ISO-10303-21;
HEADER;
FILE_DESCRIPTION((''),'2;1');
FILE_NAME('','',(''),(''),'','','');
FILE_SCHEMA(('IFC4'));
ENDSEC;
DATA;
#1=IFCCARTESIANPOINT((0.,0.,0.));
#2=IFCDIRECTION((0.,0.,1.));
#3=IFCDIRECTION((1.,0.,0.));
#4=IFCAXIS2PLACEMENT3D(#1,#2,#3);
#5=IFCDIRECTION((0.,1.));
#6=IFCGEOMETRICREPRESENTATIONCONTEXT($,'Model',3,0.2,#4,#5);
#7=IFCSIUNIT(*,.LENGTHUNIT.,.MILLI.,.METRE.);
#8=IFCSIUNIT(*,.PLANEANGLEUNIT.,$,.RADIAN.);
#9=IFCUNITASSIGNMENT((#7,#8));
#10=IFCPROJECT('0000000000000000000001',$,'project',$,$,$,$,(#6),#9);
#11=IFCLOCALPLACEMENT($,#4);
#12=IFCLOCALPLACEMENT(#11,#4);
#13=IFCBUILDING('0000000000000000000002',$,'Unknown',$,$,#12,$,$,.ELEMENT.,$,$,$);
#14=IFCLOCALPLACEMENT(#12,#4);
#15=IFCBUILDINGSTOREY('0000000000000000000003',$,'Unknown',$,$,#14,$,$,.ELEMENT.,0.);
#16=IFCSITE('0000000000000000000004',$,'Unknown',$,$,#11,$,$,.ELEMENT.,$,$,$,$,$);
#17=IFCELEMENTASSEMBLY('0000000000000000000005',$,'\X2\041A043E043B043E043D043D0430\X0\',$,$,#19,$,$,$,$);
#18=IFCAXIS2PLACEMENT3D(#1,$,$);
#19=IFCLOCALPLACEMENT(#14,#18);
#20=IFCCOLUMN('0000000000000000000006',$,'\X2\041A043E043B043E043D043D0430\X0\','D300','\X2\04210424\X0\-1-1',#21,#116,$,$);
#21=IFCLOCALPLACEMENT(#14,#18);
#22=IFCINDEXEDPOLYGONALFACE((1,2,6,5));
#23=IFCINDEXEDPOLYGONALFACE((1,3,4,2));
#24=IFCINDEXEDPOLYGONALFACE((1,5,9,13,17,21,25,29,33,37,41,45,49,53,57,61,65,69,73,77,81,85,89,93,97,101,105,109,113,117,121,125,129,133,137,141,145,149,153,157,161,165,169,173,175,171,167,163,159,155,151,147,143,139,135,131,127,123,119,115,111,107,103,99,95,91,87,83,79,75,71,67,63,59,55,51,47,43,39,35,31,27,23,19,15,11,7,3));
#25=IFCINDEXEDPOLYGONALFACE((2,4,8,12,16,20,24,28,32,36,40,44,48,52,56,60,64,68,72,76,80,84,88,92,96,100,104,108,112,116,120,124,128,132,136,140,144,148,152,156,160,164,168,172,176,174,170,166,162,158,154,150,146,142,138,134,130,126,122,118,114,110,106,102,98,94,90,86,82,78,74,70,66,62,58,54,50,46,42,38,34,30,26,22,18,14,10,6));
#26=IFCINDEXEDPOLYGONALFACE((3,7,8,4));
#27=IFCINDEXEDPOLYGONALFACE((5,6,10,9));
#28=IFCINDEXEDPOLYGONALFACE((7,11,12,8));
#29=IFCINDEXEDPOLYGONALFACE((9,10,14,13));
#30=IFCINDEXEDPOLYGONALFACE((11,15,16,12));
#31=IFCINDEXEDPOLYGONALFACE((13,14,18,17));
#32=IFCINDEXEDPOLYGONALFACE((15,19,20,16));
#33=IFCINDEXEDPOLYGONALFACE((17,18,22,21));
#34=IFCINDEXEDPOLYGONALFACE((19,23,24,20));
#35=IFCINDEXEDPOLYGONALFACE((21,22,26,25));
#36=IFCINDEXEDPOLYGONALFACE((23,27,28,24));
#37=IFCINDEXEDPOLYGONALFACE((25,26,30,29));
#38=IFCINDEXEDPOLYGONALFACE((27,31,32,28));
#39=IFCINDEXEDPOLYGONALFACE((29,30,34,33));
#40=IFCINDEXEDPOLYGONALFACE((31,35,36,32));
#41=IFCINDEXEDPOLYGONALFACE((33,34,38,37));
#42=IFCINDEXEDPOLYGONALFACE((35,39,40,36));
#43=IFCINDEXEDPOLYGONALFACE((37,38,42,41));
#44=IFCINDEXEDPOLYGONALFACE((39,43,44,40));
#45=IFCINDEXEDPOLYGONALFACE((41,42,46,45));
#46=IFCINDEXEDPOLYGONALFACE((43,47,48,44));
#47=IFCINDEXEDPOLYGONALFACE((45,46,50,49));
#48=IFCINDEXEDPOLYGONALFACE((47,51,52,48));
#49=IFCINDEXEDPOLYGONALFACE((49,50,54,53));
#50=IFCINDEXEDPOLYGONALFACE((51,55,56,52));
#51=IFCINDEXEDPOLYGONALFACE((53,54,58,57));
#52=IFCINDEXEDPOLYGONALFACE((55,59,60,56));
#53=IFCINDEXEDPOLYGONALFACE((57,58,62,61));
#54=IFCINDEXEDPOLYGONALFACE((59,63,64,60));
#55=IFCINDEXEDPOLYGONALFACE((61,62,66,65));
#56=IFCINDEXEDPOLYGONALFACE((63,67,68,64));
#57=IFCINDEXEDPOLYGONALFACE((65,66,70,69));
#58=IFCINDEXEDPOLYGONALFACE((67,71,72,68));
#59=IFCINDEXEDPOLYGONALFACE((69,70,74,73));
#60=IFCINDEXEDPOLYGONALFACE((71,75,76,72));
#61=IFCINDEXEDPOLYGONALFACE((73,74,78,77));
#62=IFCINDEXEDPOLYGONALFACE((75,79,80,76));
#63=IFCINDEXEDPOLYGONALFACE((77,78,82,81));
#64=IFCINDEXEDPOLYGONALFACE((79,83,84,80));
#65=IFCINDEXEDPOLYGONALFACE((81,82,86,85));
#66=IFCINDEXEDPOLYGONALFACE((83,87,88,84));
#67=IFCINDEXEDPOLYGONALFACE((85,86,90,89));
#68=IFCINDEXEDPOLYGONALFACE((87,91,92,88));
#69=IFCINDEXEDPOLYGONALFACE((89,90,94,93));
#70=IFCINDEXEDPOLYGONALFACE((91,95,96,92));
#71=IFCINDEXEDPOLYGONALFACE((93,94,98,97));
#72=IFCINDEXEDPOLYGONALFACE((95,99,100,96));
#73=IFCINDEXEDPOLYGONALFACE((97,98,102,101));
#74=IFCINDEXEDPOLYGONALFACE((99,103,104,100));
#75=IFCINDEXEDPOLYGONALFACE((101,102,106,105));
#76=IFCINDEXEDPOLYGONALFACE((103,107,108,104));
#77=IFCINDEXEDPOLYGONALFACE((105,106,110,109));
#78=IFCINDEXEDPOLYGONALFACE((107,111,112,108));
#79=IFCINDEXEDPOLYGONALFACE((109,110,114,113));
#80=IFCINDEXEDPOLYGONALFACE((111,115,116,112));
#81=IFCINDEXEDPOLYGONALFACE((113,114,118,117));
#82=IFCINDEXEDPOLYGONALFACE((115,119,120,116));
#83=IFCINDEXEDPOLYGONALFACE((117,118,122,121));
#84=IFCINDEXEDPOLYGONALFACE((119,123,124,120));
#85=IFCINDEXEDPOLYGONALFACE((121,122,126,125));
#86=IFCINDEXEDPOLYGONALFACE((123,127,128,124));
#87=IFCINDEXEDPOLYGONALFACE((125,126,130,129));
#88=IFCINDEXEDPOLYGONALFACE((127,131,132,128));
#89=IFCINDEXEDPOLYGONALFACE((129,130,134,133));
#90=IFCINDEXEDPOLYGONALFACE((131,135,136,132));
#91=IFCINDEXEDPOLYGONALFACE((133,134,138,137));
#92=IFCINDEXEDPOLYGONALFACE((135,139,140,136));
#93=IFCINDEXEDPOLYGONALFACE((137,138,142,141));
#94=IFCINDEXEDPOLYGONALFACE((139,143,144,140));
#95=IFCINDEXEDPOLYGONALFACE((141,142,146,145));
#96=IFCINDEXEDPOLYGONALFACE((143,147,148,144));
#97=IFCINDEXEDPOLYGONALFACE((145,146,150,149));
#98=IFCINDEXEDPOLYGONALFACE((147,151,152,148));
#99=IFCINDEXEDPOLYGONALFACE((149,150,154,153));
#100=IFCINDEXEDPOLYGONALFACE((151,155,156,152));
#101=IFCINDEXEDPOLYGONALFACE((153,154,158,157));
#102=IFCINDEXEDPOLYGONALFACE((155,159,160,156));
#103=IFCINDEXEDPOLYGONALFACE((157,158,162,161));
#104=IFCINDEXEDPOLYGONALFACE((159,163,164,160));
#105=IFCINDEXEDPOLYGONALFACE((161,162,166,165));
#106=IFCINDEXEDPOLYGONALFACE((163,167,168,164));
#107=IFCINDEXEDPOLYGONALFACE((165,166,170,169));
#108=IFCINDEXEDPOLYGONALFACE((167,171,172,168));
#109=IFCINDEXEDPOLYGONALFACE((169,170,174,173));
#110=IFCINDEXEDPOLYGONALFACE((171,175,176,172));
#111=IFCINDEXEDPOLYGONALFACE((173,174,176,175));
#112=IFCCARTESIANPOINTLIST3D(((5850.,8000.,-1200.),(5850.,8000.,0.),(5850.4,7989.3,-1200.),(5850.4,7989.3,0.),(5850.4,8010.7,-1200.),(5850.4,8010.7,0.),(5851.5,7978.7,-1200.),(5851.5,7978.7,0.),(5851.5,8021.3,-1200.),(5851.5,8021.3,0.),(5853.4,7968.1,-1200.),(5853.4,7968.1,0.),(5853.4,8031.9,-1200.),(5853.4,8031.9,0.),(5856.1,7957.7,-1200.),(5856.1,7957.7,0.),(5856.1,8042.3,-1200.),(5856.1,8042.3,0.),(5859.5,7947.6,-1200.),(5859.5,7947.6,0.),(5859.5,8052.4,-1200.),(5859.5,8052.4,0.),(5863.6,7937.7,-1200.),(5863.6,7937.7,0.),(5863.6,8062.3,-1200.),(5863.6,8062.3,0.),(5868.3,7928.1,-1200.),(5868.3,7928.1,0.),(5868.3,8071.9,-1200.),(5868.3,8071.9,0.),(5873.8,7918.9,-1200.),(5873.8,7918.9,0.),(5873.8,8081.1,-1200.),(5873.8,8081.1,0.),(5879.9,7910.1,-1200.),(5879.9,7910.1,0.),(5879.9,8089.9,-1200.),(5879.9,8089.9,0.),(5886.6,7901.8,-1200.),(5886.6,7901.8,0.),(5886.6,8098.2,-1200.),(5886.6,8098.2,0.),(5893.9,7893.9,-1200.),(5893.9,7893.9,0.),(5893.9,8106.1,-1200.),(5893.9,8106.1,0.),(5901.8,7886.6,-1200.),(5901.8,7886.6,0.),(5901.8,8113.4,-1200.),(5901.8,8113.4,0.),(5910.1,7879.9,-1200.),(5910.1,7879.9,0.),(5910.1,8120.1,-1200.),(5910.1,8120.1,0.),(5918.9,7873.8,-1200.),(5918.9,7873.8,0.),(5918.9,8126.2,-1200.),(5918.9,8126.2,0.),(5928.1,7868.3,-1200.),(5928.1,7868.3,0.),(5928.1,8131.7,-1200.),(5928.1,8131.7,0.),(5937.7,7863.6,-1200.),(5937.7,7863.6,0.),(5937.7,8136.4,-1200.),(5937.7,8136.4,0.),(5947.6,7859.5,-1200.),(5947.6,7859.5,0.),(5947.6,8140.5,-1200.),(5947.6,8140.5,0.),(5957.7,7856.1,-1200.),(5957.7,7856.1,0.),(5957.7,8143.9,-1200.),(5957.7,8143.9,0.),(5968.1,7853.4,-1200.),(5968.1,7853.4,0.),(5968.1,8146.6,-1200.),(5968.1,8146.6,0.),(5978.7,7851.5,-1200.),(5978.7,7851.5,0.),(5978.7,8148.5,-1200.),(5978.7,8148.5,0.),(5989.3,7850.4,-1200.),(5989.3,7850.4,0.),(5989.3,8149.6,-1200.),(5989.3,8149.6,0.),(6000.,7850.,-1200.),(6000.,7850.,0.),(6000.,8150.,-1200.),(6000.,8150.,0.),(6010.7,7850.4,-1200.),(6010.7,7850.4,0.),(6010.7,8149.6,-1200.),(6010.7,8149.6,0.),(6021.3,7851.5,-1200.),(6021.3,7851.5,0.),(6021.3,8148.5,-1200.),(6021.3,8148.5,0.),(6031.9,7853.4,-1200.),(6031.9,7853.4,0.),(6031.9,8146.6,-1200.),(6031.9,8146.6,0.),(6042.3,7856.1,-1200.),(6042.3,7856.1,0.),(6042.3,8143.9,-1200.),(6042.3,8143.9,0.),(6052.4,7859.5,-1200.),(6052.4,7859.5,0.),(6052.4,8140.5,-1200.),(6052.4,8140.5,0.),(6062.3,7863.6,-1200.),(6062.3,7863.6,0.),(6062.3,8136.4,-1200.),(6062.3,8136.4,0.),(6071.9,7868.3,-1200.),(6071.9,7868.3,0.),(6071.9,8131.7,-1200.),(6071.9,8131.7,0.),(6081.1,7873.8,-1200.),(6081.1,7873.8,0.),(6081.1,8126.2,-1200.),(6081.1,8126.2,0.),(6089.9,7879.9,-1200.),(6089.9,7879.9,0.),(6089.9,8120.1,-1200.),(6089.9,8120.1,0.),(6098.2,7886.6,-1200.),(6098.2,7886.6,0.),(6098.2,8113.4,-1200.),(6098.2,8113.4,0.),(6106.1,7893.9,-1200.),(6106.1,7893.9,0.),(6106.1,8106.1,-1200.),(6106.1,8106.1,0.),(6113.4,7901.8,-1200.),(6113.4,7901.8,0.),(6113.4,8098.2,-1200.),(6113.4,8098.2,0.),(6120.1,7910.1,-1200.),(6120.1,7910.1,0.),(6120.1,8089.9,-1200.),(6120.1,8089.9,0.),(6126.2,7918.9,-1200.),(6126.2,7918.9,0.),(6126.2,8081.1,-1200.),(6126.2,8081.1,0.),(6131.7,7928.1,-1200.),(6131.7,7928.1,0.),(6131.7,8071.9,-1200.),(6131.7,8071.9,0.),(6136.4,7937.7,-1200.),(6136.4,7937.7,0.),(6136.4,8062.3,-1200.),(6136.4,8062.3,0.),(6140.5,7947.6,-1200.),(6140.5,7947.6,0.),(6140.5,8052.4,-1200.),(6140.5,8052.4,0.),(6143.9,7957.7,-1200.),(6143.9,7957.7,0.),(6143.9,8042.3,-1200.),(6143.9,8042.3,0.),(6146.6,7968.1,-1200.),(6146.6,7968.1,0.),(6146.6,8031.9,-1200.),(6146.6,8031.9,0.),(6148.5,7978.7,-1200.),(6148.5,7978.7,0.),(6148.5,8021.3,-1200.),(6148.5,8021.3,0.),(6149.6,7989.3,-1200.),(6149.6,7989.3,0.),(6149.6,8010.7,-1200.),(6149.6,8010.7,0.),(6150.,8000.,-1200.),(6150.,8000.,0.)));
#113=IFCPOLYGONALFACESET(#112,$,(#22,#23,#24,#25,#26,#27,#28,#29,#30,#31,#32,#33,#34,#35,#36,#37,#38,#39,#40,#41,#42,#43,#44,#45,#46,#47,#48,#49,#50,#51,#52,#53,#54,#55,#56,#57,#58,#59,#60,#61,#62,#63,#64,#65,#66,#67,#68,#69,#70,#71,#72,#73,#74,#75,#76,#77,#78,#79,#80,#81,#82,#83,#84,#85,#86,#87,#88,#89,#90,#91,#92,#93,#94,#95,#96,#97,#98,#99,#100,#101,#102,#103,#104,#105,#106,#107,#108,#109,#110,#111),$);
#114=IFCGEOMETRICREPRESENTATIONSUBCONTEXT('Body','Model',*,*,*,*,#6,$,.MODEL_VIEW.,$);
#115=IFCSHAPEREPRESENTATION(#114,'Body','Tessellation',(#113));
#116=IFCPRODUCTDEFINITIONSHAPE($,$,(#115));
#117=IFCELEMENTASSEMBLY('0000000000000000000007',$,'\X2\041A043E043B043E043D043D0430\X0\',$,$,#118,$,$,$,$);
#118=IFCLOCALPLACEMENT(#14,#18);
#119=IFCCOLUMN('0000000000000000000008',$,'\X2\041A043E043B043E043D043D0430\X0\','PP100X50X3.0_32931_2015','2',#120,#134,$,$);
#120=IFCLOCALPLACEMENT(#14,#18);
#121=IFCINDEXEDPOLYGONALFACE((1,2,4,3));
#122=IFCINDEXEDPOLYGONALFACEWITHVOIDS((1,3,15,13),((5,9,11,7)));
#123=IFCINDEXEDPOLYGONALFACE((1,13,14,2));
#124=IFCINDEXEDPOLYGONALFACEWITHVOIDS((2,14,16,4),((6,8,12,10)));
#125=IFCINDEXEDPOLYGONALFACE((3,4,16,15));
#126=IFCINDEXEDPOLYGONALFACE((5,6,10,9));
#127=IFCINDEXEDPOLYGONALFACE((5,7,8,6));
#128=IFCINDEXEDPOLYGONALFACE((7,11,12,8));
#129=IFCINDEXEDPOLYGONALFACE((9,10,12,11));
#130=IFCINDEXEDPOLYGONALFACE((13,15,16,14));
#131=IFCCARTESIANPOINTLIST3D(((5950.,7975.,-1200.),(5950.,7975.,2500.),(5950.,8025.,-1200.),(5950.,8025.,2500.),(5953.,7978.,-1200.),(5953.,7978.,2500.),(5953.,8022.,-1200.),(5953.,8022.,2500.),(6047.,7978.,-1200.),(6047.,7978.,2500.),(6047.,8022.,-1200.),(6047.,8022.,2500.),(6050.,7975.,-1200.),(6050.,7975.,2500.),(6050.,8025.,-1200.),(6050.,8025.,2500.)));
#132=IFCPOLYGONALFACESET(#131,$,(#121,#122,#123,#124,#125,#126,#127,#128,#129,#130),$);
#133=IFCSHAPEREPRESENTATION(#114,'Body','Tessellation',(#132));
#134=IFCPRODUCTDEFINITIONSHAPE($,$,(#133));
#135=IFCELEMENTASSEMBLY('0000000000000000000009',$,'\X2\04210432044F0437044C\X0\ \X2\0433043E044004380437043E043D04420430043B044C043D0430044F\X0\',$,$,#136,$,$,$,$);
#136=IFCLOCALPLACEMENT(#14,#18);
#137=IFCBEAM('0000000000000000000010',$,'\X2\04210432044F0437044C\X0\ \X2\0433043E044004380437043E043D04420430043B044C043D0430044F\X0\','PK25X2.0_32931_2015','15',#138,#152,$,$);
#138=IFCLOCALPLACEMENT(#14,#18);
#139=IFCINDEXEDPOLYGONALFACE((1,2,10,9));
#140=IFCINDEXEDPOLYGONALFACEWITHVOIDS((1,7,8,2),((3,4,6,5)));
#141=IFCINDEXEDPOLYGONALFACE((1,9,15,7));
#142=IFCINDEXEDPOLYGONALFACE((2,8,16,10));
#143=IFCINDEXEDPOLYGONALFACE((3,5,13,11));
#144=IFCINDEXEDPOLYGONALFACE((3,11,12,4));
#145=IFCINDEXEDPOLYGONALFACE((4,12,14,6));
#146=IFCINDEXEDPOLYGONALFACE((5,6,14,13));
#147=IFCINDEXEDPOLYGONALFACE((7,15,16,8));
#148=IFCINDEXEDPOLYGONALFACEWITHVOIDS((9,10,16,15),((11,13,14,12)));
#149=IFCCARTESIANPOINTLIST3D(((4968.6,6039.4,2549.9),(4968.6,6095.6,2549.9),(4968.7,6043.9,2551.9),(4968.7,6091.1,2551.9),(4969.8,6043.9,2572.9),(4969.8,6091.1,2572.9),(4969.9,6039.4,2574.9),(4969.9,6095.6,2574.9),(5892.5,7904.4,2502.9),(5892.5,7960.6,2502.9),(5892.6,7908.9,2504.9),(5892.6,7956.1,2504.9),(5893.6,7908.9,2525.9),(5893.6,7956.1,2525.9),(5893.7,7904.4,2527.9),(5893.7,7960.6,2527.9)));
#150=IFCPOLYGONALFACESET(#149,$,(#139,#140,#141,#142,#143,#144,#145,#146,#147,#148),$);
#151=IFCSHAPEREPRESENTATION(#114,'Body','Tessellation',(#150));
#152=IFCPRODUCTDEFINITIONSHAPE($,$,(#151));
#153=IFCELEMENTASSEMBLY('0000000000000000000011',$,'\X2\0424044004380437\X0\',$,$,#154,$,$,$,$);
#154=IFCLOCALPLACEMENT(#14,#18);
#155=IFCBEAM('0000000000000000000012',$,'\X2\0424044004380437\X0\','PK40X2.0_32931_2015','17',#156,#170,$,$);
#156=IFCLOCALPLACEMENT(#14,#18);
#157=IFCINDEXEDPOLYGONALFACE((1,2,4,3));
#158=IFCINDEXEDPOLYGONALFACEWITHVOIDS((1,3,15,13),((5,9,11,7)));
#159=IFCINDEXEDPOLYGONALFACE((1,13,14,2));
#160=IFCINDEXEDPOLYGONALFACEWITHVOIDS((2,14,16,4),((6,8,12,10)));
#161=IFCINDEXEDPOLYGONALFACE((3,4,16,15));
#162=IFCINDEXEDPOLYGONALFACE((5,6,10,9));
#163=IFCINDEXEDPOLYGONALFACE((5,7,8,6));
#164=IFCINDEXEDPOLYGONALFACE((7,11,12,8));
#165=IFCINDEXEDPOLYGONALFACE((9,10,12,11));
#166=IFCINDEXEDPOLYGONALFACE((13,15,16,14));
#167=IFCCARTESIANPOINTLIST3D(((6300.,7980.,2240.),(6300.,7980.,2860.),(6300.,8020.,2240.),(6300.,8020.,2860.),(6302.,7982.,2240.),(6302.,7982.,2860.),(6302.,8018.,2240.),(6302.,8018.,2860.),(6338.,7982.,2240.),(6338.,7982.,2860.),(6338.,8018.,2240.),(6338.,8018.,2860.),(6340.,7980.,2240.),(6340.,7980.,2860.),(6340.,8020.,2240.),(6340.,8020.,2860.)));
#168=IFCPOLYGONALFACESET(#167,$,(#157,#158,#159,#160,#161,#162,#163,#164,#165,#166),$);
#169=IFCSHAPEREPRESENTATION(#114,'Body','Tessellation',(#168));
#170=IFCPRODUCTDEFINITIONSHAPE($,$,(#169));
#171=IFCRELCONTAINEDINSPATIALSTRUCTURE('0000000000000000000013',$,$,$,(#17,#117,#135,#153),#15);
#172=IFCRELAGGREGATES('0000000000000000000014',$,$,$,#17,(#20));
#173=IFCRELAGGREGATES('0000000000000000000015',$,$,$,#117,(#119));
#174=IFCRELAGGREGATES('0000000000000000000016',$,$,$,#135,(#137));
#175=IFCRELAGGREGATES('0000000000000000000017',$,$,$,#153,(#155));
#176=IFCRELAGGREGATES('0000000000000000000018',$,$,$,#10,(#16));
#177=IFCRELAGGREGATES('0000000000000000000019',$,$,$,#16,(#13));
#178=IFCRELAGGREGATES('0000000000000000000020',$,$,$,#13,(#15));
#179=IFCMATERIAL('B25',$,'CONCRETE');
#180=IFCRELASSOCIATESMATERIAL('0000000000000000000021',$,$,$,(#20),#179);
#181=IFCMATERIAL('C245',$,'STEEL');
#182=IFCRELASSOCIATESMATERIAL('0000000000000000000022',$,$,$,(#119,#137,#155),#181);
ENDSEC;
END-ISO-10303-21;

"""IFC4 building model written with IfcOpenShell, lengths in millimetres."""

from ifc_helpers import new_model, si_unit, direction, frame, origin_with_axes, place, context, subcontext, project, spatial, line, indexed_curve, outline, extrude, material, element, aggregate, save


model = new_model("IFC4")

# Units and contexts
model_context = context("Model", 3, precision=0.2, world=origin_with_axes(), true_north=direction((0.0, 1.0)))
body_context = subcontext(model_context, "Body", "Model", "MODEL_VIEW")
ifc_project = project(units=[si_unit("LENGTHUNIT", "METRE", prefix="MILLI"), si_unit("PLANEANGLEUNIT", "RADIAN")], contexts=[model_context])

# Site, building, storey
site_placement = place(None, origin_with_axes())
site = spatial("IfcSite", under=ifc_project, at=site_placement, Name="Unknown", CompositionType="ELEMENT")
building_placement = place(site_placement, origin_with_axes())
building = spatial("IfcBuilding", under=site, at=building_placement, Name="Unknown", CompositionType="ELEMENT")
storey_placement = place(building_placement, origin_with_axes())
storey = spatial("IfcBuildingStorey", under=building, at=storey_placement, Name="Unknown", CompositionType="ELEMENT", Elevation=0.0)

# Element assemblies, columns
assembly_1_placement = place(storey_placement, frame((6000.0, 8000.0, -1200.0), z_axis=(-1.0, 0.0, 0.0), x_axis=(0.0, 0.0, 1.0)))
assembly_1 = element("IfcElementAssembly", 1, at=assembly_1_placement, inside=storey, Name="Колонна")
ifc_material_1 = material(Name="B25", Category="CONCRETE")
column_1_placement = place(assembly_1_placement, origin_with_axes())
column_1 = element("IfcColumn", 2, at=column_1_placement, material=ifc_material_1, Name="Колонна", Description="D300", ObjectType="СФ-1-1", context=body_context, shape_type="SolidModel", body=[
    extrude(outline(indexed_curve([(150.0, 0.0), (149.6, 10.7), (148.5, 21.3), (146.6, 31.9), (143.9, 42.3), (140.5, 52.4), (136.4, 62.3), (131.7, 71.9), (126.2, 81.1), (120.1, 89.9), (113.4, 98.2), (106.1, 106.1), (98.2, 113.4), (89.9, 120.1), (81.1, 126.2), (71.9, 131.7), (62.3, 136.4), (52.4, 140.5), (42.3, 143.9), (31.9, 146.6), (21.3, 148.5), (10.7, 149.6), (0.0, 150.0), (-10.7, 149.6), (-21.3, 148.5), (-31.9, 146.6), (-42.3, 143.9), (-52.4, 140.5), (-62.3, 136.4), (-71.9, 131.7), (-81.1, 126.2), (-89.9, 120.1), (-98.2, 113.4), (-106.1, 106.1), (-113.4, 98.2), (-120.1, 89.9), (-126.2, 81.1), (-131.7, 71.9), (-136.4, 62.3), (-140.5, 52.4), (-143.9, 42.3), (-146.6, 31.9), (-148.5, 21.3), (-149.6, 10.7), (-150.0, 0.0), (-149.6, -10.7), (-148.5, -21.3), (-146.6, -31.9), (-143.9, -42.3), (-140.5, -52.4), (-136.4, -62.3), (-131.7, -71.9), (-126.2, -81.1), (-120.1, -89.9), (-113.4, -98.2), (-106.1, -106.1), (-98.2, -113.4), (-89.9, -120.1), (-81.1, -126.2), (-71.9, -131.7), (-62.3, -136.4), (-52.4, -140.5), (-42.3, -143.9), (-31.9, -146.6), (-21.3, -148.5), (-10.7, -149.6), (0.0, -150.0), (10.7, -149.6), (21.3, -148.5), (31.9, -146.6), (42.3, -143.9), (52.4, -140.5), (62.3, -136.4), (71.9, -131.7), (81.1, -126.2), (89.9, -120.1), (98.2, -113.4), (106.1, -106.1), (113.4, -98.2), (120.1, -89.9), (126.2, -81.1), (131.7, -71.9), (136.4, -62.3), (140.5, -52.4), (143.9, -42.3), (146.6, -31.9), (148.5, -21.3), (149.6, -10.7)], segments=[line(1, 2, 3, 4, 5, 6, 7, 8, 9, 10, 11, 12, 13, 14, 15, 16, 17, 18, 19, 20, 21, 22, 23, 24, 25, 26, 27, 28, 29, 30, 31, 32, 33, 34, 35, 36, 37, 38, 39, 40, 41, 42, 43, 44, 45, 46, 47, 48, 49, 50, 51, 52, 53, 54, 55, 56, 57, 58, 59, 60, 61, 62, 63, 64, 65, 66, 67, 68, 69, 70, 71, 72, 73, 74, 75, 76, 77, 78, 79, 80, 81, 82, 83, 84, 85, 86, 87, 88, 1)])), frame((0.0, 0.0, 0.0), z_axis=(-1.0, 0.0, 0.0), x_axis=(0.0, 0.0, 1.0)), (0.0, 0.0, -1.0), 1200.0),
])
aggregate(assembly_1, [column_1])
assembly_2_placement = place(storey_placement, frame((6000.0, 8000.0, -1200.0), z_axis=(0.0, -1.0, 0.0), x_axis=(0.0, 0.0, 1.0)))
assembly_2 = element("IfcElementAssembly", 3, at=assembly_2_placement, inside=storey, Name="Колонна")
ifc_material_2 = material(Name="C245", Category="STEEL")
column_2_placement = place(assembly_2_placement, origin_with_axes())
column_2 = element("IfcColumn", 4, at=column_2_placement, material=ifc_material_2, Name="Колонна", Description="PP100X50X3.0_32931_2015", ObjectType="2", context=body_context, shape_type="SolidModel", body=[
    extrude(outline(indexed_curve([(-25.0, -50.0), (25.0, -50.0), (25.0, 50.0), (-25.0, 50.0)], segments=[line(1, 2, 3, 4, 1)]), holes=[indexed_curve([(-22.0, -47.0), (-22.0, 47.0), (22.0, 47.0), (22.0, -47.0)], segments=[line(1, 2, 3, 4, 1)])]), frame((0.0, 0.0, 0.0), z_axis=(-1.0, 0.0, 0.0), x_axis=(0.0, 0.0, 1.0)), (0.0, 0.0, -1.0), 3700.0),
])
aggregate(assembly_2, [column_2])

# Element assembly, beam, voiding features
assembly_3_placement = place(storey_placement, frame((5920.3, 7987.4, 2514.0), z_axis=(-0.894709, 0.444326, 0.045494), x_axis=(-0.443753, -0.895865, 0.022564)))
assembly_3 = element("IfcElementAssembly", 5, at=assembly_3_placement, inside=storey, Name="Связь горизонтальная")
beam_1_placement = place(assembly_3_placement, origin_with_axes())
beam_1 = element("IfcBeam", 6, at=beam_1_placement, material=ifc_material_2, Name="Связь горизонтальная", Description="PK25X2.0_32931_2015", ObjectType="15", context=body_context, shape_type="SolidModel", body=[
    extrude(outline(indexed_curve([(-12.5, -12.5), (12.5, -12.5), (12.5, 12.5), (-12.5, 12.5)], segments=[line(1, 2, 3, 4, 1)]), holes=[indexed_curve([(-10.5, -10.5), (-10.5, 10.5), (10.5, 10.5), (10.5, -10.5)], segments=[line(1, 2, 3, 4, 1)])]), frame((0.0, 0.0, 0.0), z_axis=(-1.0, 0.0, 0.0), x_axis=(0.0, 0.0, 1.0)), (0.0, 0.0, -1.0), 2204.4),
])
voiding_feature_1_placement = place(beam_1_placement, frame((3193.8, 12.5, -493.2), z_axis=(-0.444326, 0.0, -0.895865), x_axis=(-0.895865, 0.0, 0.444326)))
element("IfcVoidingFeature", 7, at=voiding_feature_1_placement, cuts=beam_1, Name="CUT_BEAM", ObjectType="(?)", PredefinedType="HOLE", context=body_context, shape_type="SolidModel", body=[
    extrude(outline(indexed_curve([(-25.0, -25.0), (25.0, -25.0), (25.0, 25.0), (-25.0, 25.0)], segments=[line(1, 2, 3, 4, 1)])), frame((0.0, 0.0, 0.0), z_axis=(-1.0, 0.0, 0.0), x_axis=(0.0, 0.0, 1.0)), (0.0, 0.0, -1.0), 2220.1),
])
voiding_feature_2_placement = place(beam_1_placement, frame((999.5, 12.5, -493.2), z_axis=(-0.444326, 0.0, -0.895865), x_axis=(-0.895865, 0.0, 0.444326)))
element("IfcVoidingFeature", 8, at=voiding_feature_2_placement, cuts=beam_1, Name="CUT_BEAM", ObjectType="(?)", PredefinedType="HOLE", context=body_context, shape_type="SolidModel", body=[
    extrude(outline(indexed_curve([(-25.0, -25.0), (25.0, -25.0), (25.0, 25.0), (-25.0, 25.0)], segments=[line(1, 2, 3, 4, 1)])), frame((0.0, 0.0, 0.0), z_axis=(-1.0, 0.0, 0.0), x_axis=(0.0, 0.0, 1.0)), (0.0, 0.0, -1.0), 2220.1),
])
aggregate(assembly_3, [beam_1])

# Element assembly, beam
assembly_4_placement = place(storey_placement, frame((6320.0, -300.0, 2880.0), z_axis=(1.0, 0.0, 0.0), x_axis=(0.0, 1.0, 0.0)))
assembly_4 = element("IfcElementAssembly", 9, at=assembly_4_placement, inside=storey, Name="Фриз")
beam_2_placement = place(assembly_4_placement, frame((8300.0, -20.0, 0.0), z_axis=(1.0, 0.0, 0.0), x_axis=(0.0, -1.0, 0.0)))
beam_2 = element("IfcBeam", 10, at=beam_2_placement, material=ifc_material_2, Name="Фриз", Description="PK40X2.0_32931_2015", ObjectType="17", context=body_context, shape_type="SolidModel", body=[
    extrude(outline(indexed_curve([(-20.0, -20.0), (20.0, -20.0), (20.0, 20.0), (-20.0, 20.0)], segments=[line(1, 2, 3, 4, 1)]), holes=[indexed_curve([(-18.0, -18.0), (-18.0, 18.0), (18.0, 18.0), (18.0, -18.0)], segments=[line(1, 2, 3, 4, 1)])]), frame((0.0, 0.0, 0.0), z_axis=(-1.0, 0.0, 0.0), x_axis=(0.0, 0.0, 1.0)), (0.0, 0.0, -1.0), 620.0),
])
aggregate(assembly_4, [beam_2])

save(model, "model.ifc")
